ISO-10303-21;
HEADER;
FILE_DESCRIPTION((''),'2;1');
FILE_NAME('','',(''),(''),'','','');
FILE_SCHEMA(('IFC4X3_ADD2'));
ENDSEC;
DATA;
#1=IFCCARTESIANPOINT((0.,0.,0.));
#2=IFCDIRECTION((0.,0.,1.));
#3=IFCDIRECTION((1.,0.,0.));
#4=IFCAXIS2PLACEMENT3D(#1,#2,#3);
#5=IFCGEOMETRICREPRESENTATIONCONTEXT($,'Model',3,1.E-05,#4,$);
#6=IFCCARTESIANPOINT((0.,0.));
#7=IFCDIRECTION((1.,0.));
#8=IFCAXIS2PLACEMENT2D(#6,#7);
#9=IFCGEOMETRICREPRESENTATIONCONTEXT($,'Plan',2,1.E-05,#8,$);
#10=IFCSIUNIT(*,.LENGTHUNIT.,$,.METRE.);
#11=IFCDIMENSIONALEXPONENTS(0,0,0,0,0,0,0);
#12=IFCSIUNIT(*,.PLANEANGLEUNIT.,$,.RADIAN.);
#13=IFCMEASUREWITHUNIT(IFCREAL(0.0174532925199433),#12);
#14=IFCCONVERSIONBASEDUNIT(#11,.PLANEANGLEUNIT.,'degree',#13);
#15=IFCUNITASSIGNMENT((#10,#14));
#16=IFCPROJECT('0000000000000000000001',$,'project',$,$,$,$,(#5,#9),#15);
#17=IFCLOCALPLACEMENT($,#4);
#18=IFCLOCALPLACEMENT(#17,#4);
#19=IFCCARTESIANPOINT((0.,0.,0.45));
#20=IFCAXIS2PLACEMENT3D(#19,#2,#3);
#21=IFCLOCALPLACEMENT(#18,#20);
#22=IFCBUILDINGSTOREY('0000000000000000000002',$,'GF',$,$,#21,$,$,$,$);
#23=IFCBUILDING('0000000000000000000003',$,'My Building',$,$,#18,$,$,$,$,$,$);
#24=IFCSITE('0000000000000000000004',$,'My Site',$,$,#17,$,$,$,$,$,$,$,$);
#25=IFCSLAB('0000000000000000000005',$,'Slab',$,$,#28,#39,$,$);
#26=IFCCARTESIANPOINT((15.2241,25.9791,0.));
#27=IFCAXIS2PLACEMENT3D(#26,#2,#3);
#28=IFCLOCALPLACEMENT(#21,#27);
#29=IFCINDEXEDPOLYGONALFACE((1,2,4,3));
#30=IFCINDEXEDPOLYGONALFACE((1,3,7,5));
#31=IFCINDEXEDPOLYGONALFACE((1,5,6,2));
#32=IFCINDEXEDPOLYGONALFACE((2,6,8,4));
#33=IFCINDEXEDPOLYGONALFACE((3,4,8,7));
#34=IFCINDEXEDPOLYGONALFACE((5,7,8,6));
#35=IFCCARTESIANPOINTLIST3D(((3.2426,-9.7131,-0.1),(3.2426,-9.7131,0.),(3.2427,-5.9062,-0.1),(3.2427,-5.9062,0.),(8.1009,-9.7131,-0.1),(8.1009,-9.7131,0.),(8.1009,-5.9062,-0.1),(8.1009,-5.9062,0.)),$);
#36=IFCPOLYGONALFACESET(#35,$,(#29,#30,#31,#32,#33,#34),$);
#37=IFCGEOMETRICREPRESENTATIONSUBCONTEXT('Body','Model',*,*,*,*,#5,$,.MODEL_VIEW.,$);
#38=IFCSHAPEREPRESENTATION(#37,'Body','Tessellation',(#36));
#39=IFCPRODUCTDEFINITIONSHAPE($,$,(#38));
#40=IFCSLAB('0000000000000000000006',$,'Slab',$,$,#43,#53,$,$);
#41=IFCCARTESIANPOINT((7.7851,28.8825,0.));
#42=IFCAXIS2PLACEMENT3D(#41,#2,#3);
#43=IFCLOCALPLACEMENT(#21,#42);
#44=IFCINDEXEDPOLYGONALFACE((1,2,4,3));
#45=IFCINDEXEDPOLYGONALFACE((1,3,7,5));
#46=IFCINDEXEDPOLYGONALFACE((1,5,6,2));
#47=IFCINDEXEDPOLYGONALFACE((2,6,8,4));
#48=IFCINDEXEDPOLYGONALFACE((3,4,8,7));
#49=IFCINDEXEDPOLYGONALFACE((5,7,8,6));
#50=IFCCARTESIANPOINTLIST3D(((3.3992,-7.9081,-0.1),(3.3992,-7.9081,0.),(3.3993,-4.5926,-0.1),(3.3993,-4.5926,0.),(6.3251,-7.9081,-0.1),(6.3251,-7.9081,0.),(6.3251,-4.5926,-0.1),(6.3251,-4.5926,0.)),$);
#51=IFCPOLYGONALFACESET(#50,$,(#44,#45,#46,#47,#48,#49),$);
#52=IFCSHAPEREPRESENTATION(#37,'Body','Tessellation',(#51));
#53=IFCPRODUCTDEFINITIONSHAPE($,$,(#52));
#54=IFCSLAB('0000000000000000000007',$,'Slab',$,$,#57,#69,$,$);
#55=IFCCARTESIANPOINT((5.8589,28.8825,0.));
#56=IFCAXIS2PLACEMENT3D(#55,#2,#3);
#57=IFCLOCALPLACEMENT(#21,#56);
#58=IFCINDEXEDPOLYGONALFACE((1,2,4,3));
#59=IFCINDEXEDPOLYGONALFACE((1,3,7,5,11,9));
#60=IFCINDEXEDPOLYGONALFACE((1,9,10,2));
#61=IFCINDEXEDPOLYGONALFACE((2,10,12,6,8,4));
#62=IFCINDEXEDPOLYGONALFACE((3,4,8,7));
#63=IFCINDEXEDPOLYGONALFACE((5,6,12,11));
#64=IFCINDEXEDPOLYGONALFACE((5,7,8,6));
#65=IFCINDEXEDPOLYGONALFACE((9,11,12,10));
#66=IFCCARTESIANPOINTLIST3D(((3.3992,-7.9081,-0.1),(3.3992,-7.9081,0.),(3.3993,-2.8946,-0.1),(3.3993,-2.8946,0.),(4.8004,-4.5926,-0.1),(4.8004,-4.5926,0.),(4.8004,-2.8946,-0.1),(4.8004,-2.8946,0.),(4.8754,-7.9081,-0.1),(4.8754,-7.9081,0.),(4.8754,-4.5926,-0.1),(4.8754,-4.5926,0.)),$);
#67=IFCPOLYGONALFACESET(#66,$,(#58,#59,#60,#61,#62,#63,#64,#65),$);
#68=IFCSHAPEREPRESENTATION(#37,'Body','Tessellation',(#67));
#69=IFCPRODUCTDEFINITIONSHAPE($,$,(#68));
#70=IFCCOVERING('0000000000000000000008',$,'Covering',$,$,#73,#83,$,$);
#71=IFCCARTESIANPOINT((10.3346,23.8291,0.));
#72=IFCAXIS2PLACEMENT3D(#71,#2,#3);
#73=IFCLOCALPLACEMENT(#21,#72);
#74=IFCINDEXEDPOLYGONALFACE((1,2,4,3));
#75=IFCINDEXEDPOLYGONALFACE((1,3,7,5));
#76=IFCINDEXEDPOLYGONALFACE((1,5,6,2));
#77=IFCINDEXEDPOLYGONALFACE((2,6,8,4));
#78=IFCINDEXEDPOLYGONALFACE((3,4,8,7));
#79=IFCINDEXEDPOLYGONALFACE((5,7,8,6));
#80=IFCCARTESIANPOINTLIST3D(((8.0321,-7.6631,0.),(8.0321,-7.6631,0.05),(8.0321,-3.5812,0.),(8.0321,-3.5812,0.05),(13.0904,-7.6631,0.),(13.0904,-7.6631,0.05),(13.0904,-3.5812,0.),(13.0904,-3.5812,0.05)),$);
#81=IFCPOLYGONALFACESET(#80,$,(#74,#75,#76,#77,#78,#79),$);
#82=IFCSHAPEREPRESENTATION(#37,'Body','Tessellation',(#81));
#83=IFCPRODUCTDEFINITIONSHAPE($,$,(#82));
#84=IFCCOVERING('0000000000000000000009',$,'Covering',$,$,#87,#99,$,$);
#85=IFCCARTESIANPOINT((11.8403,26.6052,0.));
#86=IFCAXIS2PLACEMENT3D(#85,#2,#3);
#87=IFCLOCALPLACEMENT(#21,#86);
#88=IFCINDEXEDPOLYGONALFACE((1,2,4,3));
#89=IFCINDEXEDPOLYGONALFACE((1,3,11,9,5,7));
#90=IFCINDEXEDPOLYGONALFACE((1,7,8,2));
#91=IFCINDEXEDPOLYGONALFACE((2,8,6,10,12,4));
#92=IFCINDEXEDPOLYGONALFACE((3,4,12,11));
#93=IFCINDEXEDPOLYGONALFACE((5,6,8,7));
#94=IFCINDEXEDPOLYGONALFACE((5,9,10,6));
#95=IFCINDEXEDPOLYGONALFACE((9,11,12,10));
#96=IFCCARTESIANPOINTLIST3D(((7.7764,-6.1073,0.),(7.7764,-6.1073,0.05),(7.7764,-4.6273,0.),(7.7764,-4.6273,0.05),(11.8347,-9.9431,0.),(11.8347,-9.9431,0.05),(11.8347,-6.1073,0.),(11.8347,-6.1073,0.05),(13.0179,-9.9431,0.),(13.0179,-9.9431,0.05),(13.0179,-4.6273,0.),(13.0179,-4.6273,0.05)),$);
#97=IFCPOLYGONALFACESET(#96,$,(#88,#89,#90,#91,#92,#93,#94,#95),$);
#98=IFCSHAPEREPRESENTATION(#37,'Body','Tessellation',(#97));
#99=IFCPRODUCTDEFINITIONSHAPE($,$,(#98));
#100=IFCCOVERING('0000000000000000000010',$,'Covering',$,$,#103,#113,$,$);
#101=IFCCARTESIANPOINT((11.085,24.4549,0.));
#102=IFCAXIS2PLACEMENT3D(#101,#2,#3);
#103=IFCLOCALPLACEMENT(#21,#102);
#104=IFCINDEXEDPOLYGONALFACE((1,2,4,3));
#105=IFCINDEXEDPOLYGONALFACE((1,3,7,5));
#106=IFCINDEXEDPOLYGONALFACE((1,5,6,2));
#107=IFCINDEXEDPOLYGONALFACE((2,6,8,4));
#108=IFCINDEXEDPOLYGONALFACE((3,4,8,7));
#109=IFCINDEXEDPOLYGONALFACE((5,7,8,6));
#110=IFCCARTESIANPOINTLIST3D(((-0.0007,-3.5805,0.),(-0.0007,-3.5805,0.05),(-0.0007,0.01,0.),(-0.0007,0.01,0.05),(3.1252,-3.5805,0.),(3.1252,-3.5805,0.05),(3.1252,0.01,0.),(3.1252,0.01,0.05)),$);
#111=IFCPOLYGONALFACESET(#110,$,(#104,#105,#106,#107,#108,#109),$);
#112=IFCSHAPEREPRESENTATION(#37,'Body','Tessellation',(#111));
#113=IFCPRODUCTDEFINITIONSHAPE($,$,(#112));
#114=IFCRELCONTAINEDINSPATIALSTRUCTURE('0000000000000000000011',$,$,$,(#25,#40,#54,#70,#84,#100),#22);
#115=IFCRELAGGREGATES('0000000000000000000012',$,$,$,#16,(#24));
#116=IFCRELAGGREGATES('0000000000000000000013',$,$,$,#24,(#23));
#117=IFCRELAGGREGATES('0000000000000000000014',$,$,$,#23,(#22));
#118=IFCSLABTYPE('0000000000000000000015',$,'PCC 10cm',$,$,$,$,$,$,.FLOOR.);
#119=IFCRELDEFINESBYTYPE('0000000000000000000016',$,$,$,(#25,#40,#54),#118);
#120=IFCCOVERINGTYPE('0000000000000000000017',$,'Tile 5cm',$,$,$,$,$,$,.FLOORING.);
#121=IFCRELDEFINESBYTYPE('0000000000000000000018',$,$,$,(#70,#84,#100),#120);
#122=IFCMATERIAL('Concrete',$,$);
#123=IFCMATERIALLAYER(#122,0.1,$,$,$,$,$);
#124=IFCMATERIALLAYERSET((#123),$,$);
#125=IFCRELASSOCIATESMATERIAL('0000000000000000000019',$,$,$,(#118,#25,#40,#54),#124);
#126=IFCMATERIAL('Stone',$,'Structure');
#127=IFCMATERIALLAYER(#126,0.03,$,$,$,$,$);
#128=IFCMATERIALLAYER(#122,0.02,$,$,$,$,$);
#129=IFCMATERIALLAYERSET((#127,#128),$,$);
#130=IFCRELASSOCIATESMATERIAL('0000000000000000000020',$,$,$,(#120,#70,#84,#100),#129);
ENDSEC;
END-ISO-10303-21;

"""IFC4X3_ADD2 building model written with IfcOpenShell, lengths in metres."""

from ifc_helpers import new_model, entity, si_unit, converted_unit, frame, origin_with_axes, origin_2d_with_axis, place, context, subcontext, project, spatial, indexed_curve, outline, extrude, material, layer, layer_set, layer_usage, type_object, element, save


model = new_model("IFC4X3_ADD2")

# Units and contexts
model_context = context("Model", 3, precision=1e-05, world=origin_with_axes())
plan_context = context("Plan", 2, precision=1e-05, world=origin_2d_with_axis())
body_context_1 = subcontext(model_context, "Body", "Model", "MODEL_VIEW")
ifc_project = project(units=[si_unit("LENGTHUNIT", "METRE"), converted_unit("PLANEANGLEUNIT", "degree", entity("IfcReal", 0.0174532925199433), si_unit("PLANEANGLEUNIT", "RADIAN"), dimensions=[0, 0, 0, 0, 0, 0, 0])], contexts=[model_context, plan_context])

# Site, building, storey
site_placement = place(None, origin_with_axes())
site = spatial("IfcSite", under=ifc_project, at=site_placement, Name="My Site")
building_placement = place(site_placement, origin_with_axes())
building = spatial("IfcBuilding", under=site, at=building_placement, Name="My Building")
storey_placement = place(building_placement, frame((0.0, 0.0, 0.45), z_axis=(0.0, 0.0, 1.0), x_axis=(1.0, 0.0, 0.0)))
storey = spatial("IfcBuildingStorey", under=building, at=storey_placement, Name="GF")

# Slabs
ifc_material_1 = material(Name="Concrete")
ifc_layer_1 = layer(ifc_material_1, 0.1)
ifc_layer_set_1 = layer_set([ifc_layer_1])
slab_type = type_object("IfcSlabType", Name="PCC 10cm", PredefinedType="FLOOR", material=ifc_layer_set_1)
ifc_layer_usage_1 = layer_usage(ifc_layer_set_1, "AXIS3", "POSITIVE", -0.1)
slab_1_placement = place(storey_placement, frame((15.2241, 25.9791, 0.0), z_axis=(0.0, 0.0, 1.0), x_axis=(1.0, 0.0, 0.0)))
element("IfcSlab", 1, at=slab_1_placement, inside=storey, type_object=slab_type, material=ifc_layer_usage_1, Name="Slab", context=body_context_1, shape_type="SweptSolid", body=[
    extrude(outline(indexed_curve([(3.2427, -5.9062), (8.1009, -5.9062), (8.1009, -9.7131), (3.2426, -9.7131), (3.2427, -5.9062)])), frame((0.0, 0.0, -0.1), z_axis=(0.0, 0.0, 1.0), x_axis=(1.0, 0.0, 0.0)), (0.0, 0.0, 1.0), 0.1),
])
ifc_layer_usage_2 = layer_usage(ifc_layer_set_1, "AXIS3", "POSITIVE", -0.1)
slab_2_placement = place(storey_placement, frame((7.7851, 28.8825, 0.0), z_axis=(0.0, 0.0, 1.0), x_axis=(1.0, 0.0, 0.0)))
element("IfcSlab", 2, at=slab_2_placement, inside=storey, type_object=slab_type, material=ifc_layer_usage_2, Name="Slab", context=body_context_1, shape_type="SweptSolid", body=[
    extrude(outline(indexed_curve([(3.3993, -4.5926), (6.3251, -4.5926), (6.3251, -7.9081), (3.3992, -7.9081), (3.3993, -4.5926)])), frame((0.0, 0.0, -0.1), z_axis=(0.0, 0.0, 1.0), x_axis=(1.0, 0.0, 0.0)), (0.0, 0.0, 1.0), 0.1),
])
ifc_layer_usage_3 = layer_usage(ifc_layer_set_1, "AXIS3", "POSITIVE", -0.1)
slab_3_placement = place(storey_placement, frame((5.8589, 28.8825, 0.0), z_axis=(0.0, 0.0, 1.0), x_axis=(1.0, 0.0, 0.0)))
element("IfcSlab", 3, at=slab_3_placement, inside=storey, type_object=slab_type, material=ifc_layer_usage_3, Name="Slab", context=body_context_1, shape_type="SweptSolid", body=[
    extrude(outline(indexed_curve([(4.8004, -2.8946), (3.3993, -2.8946), (3.3992, -7.9081), (4.8754, -7.9081), (4.8754, -4.5926), (4.8004, -4.5926), (4.8004, -2.8946)])), frame((0.0, 0.0, -0.1), z_axis=(0.0, 0.0, 1.0), x_axis=(1.0, 0.0, 0.0)), (0.0, 0.0, 1.0), 0.1),
])

# Coverings
ifc_material_2 = material(Name="Stone", Category="Structure")
ifc_layer_2 = layer(ifc_material_2, 0.03)
ifc_layer_3 = layer(ifc_material_1, 0.02)
ifc_layer_set_2 = layer_set([ifc_layer_2, ifc_layer_3])
covering_type = type_object("IfcCoveringType", Name="Tile 5cm", PredefinedType="FLOORING", material=ifc_layer_set_2)
ifc_layer_usage_4 = layer_usage(ifc_layer_set_2, "AXIS3", "POSITIVE", 0.0)
covering_1_placement = place(storey_placement, frame((10.3346, 23.8291, 0.0), z_axis=(0.0, 0.0, 1.0), x_axis=(1.0, 0.0, 0.0)))
element("IfcCovering", 4, at=covering_1_placement, inside=storey, type_object=covering_type, material=ifc_layer_usage_4, Name="Covering", context=body_context_1, shape_type="SweptSolid", body=[
    extrude(outline(indexed_curve([(8.0321, -3.5812), (13.0904, -3.5812), (13.0904, -7.6631), (8.0321, -7.6631), (8.0321, -3.5812)])), None, (0.0, 0.0, 1.0), 0.05),
])
ifc_layer_usage_5 = layer_usage(ifc_layer_set_2, "AXIS3", "POSITIVE", 0.0)
covering_2_placement = place(storey_placement, frame((11.8403, 26.6052, 0.0), z_axis=(0.0, 0.0, 1.0), x_axis=(1.0, 0.0, 0.0)))
element("IfcCovering", 5, at=covering_2_placement, inside=storey, type_object=covering_type, material=ifc_layer_usage_5, Name="Covering", context=body_context_1, shape_type="SweptSolid", body=[
    extrude(outline(indexed_curve([(11.8347, -6.1073), (11.8347, -9.9431), (13.0179, -9.9431), (13.0179, -4.6273), (7.7764, -4.6273), (7.7764, -6.1073), (11.8347, -6.1073)])), None, (0.0, 0.0, 1.0), 0.05),
])
ifc_layer_usage_6 = layer_usage(ifc_layer_set_2, "AXIS3", "POSITIVE", 0.0)
covering_3_placement = place(storey_placement, frame((11.085, 24.4549, 0.0), z_axis=(0.0, 0.0, 1.0), x_axis=(1.0, 0.0, 0.0)))
element("IfcCovering", 6, at=covering_3_placement, inside=storey, type_object=covering_type, material=ifc_layer_usage_6, Name="Covering", context=body_context_1, shape_type="SweptSolid", body=[
    extrude(outline(indexed_curve([(-0.0007, 0.01), (3.1252, 0.01), (3.1252, -3.5805), (-0.0007, -3.5805), (-0.0007, 0.01)])), None, (0.0, 0.0, 1.0), 0.05),
])

save(model, "model.ifc")
